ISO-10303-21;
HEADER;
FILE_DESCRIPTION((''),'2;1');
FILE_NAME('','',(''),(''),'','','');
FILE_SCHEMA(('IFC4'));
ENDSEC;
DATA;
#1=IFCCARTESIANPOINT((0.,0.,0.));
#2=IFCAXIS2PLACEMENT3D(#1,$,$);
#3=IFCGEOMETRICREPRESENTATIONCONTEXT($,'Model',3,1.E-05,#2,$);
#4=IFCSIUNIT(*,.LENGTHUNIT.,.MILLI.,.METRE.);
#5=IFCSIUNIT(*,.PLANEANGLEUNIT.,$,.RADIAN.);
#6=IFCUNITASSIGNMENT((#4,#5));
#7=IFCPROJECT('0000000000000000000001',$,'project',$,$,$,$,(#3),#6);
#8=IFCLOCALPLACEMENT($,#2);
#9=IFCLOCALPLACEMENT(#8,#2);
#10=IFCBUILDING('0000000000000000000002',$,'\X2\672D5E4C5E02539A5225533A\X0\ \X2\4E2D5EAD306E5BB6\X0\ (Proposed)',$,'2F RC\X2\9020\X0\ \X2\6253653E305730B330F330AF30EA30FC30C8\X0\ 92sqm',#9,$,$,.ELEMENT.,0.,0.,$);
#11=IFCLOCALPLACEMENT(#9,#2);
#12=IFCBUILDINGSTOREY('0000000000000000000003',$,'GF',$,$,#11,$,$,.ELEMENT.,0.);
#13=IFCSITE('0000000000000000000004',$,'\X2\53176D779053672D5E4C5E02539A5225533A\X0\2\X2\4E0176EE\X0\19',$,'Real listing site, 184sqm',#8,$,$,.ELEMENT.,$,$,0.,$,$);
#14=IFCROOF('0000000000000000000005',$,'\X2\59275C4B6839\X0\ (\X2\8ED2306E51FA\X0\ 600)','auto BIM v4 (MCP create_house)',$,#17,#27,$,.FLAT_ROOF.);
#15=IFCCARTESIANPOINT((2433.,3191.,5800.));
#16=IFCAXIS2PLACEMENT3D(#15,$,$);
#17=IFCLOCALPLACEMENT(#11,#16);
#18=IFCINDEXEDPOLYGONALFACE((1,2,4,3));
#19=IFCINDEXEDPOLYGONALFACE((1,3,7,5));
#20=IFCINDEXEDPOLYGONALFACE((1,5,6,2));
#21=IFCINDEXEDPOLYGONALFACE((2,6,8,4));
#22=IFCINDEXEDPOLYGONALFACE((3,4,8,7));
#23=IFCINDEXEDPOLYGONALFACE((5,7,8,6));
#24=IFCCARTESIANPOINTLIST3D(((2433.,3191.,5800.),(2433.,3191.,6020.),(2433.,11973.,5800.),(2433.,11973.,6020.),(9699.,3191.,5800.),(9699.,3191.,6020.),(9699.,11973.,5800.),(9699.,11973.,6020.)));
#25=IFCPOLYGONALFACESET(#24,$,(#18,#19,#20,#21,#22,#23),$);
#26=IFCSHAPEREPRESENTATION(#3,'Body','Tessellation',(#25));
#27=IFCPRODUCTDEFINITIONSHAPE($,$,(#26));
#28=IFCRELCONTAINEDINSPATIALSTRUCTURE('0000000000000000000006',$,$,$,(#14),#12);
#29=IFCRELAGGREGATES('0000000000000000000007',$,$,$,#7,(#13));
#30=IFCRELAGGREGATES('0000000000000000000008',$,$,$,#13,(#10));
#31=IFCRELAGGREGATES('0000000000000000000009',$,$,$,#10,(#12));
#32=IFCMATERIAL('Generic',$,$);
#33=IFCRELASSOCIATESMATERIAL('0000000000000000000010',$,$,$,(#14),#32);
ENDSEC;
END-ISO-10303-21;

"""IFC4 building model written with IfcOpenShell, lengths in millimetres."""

from ifc_helpers import new_model, si_unit, frame, frame_2d, origin, place, context, project, spatial, rectangle, extrude, material, element, save


model = new_model("IFC4")

# Units and contexts
model_context = context("Model", 3, precision=1e-05, world=origin())
ifc_project = project(units=[si_unit("LENGTHUNIT", "METRE", prefix="MILLI"), si_unit("PLANEANGLEUNIT", "RADIAN")], contexts=[model_context])

# Site, building, storey
site_placement = place(None, origin())
site = spatial("IfcSite", under=ifc_project, at=site_placement, Name="北海道札幌市厚別区2丁目19", ObjectType="Real listing site, 184sqm", CompositionType="ELEMENT", RefElevation=0.0)
building_placement = place(site_placement, origin())
building = spatial("IfcBuilding", under=site, at=building_placement, Name="札幌市厚別区 中庭の家 (Proposed)", ObjectType="2F RC造 打放しコンクリート 92sqm", CompositionType="ELEMENT", ElevationOfRefHeight=0.0, ElevationOfTerrain=0.0)
storey_placement = place(building_placement, origin())
storey = spatial("IfcBuildingStorey", under=building, at=storey_placement, Name="GF", CompositionType="ELEMENT", Elevation=0.0)

# Shared definitions
ifc_material = material(Name="Generic")

# Roof
roof_placement = place(storey_placement, frame((2433.0, 3191.0, 5800.0)))
element("IfcRoof", 1, at=roof_placement, inside=storey, material=ifc_material, Name="大屋根 (軒の出 600)", Description="auto BIM v4 (MCP create_house)", PredefinedType="FLAT_ROOF", context=model_context, shape_type="SweptSolid", body=[
    extrude(rectangle(XDim=7266.0, YDim=8782.0, at=frame_2d((3633.0, 4391.0))), frame((2433.0, 3191.0, 5800.0)), (0.0, 0.0, 1.0), 220.0),
])

save(model, "model.ifc")
